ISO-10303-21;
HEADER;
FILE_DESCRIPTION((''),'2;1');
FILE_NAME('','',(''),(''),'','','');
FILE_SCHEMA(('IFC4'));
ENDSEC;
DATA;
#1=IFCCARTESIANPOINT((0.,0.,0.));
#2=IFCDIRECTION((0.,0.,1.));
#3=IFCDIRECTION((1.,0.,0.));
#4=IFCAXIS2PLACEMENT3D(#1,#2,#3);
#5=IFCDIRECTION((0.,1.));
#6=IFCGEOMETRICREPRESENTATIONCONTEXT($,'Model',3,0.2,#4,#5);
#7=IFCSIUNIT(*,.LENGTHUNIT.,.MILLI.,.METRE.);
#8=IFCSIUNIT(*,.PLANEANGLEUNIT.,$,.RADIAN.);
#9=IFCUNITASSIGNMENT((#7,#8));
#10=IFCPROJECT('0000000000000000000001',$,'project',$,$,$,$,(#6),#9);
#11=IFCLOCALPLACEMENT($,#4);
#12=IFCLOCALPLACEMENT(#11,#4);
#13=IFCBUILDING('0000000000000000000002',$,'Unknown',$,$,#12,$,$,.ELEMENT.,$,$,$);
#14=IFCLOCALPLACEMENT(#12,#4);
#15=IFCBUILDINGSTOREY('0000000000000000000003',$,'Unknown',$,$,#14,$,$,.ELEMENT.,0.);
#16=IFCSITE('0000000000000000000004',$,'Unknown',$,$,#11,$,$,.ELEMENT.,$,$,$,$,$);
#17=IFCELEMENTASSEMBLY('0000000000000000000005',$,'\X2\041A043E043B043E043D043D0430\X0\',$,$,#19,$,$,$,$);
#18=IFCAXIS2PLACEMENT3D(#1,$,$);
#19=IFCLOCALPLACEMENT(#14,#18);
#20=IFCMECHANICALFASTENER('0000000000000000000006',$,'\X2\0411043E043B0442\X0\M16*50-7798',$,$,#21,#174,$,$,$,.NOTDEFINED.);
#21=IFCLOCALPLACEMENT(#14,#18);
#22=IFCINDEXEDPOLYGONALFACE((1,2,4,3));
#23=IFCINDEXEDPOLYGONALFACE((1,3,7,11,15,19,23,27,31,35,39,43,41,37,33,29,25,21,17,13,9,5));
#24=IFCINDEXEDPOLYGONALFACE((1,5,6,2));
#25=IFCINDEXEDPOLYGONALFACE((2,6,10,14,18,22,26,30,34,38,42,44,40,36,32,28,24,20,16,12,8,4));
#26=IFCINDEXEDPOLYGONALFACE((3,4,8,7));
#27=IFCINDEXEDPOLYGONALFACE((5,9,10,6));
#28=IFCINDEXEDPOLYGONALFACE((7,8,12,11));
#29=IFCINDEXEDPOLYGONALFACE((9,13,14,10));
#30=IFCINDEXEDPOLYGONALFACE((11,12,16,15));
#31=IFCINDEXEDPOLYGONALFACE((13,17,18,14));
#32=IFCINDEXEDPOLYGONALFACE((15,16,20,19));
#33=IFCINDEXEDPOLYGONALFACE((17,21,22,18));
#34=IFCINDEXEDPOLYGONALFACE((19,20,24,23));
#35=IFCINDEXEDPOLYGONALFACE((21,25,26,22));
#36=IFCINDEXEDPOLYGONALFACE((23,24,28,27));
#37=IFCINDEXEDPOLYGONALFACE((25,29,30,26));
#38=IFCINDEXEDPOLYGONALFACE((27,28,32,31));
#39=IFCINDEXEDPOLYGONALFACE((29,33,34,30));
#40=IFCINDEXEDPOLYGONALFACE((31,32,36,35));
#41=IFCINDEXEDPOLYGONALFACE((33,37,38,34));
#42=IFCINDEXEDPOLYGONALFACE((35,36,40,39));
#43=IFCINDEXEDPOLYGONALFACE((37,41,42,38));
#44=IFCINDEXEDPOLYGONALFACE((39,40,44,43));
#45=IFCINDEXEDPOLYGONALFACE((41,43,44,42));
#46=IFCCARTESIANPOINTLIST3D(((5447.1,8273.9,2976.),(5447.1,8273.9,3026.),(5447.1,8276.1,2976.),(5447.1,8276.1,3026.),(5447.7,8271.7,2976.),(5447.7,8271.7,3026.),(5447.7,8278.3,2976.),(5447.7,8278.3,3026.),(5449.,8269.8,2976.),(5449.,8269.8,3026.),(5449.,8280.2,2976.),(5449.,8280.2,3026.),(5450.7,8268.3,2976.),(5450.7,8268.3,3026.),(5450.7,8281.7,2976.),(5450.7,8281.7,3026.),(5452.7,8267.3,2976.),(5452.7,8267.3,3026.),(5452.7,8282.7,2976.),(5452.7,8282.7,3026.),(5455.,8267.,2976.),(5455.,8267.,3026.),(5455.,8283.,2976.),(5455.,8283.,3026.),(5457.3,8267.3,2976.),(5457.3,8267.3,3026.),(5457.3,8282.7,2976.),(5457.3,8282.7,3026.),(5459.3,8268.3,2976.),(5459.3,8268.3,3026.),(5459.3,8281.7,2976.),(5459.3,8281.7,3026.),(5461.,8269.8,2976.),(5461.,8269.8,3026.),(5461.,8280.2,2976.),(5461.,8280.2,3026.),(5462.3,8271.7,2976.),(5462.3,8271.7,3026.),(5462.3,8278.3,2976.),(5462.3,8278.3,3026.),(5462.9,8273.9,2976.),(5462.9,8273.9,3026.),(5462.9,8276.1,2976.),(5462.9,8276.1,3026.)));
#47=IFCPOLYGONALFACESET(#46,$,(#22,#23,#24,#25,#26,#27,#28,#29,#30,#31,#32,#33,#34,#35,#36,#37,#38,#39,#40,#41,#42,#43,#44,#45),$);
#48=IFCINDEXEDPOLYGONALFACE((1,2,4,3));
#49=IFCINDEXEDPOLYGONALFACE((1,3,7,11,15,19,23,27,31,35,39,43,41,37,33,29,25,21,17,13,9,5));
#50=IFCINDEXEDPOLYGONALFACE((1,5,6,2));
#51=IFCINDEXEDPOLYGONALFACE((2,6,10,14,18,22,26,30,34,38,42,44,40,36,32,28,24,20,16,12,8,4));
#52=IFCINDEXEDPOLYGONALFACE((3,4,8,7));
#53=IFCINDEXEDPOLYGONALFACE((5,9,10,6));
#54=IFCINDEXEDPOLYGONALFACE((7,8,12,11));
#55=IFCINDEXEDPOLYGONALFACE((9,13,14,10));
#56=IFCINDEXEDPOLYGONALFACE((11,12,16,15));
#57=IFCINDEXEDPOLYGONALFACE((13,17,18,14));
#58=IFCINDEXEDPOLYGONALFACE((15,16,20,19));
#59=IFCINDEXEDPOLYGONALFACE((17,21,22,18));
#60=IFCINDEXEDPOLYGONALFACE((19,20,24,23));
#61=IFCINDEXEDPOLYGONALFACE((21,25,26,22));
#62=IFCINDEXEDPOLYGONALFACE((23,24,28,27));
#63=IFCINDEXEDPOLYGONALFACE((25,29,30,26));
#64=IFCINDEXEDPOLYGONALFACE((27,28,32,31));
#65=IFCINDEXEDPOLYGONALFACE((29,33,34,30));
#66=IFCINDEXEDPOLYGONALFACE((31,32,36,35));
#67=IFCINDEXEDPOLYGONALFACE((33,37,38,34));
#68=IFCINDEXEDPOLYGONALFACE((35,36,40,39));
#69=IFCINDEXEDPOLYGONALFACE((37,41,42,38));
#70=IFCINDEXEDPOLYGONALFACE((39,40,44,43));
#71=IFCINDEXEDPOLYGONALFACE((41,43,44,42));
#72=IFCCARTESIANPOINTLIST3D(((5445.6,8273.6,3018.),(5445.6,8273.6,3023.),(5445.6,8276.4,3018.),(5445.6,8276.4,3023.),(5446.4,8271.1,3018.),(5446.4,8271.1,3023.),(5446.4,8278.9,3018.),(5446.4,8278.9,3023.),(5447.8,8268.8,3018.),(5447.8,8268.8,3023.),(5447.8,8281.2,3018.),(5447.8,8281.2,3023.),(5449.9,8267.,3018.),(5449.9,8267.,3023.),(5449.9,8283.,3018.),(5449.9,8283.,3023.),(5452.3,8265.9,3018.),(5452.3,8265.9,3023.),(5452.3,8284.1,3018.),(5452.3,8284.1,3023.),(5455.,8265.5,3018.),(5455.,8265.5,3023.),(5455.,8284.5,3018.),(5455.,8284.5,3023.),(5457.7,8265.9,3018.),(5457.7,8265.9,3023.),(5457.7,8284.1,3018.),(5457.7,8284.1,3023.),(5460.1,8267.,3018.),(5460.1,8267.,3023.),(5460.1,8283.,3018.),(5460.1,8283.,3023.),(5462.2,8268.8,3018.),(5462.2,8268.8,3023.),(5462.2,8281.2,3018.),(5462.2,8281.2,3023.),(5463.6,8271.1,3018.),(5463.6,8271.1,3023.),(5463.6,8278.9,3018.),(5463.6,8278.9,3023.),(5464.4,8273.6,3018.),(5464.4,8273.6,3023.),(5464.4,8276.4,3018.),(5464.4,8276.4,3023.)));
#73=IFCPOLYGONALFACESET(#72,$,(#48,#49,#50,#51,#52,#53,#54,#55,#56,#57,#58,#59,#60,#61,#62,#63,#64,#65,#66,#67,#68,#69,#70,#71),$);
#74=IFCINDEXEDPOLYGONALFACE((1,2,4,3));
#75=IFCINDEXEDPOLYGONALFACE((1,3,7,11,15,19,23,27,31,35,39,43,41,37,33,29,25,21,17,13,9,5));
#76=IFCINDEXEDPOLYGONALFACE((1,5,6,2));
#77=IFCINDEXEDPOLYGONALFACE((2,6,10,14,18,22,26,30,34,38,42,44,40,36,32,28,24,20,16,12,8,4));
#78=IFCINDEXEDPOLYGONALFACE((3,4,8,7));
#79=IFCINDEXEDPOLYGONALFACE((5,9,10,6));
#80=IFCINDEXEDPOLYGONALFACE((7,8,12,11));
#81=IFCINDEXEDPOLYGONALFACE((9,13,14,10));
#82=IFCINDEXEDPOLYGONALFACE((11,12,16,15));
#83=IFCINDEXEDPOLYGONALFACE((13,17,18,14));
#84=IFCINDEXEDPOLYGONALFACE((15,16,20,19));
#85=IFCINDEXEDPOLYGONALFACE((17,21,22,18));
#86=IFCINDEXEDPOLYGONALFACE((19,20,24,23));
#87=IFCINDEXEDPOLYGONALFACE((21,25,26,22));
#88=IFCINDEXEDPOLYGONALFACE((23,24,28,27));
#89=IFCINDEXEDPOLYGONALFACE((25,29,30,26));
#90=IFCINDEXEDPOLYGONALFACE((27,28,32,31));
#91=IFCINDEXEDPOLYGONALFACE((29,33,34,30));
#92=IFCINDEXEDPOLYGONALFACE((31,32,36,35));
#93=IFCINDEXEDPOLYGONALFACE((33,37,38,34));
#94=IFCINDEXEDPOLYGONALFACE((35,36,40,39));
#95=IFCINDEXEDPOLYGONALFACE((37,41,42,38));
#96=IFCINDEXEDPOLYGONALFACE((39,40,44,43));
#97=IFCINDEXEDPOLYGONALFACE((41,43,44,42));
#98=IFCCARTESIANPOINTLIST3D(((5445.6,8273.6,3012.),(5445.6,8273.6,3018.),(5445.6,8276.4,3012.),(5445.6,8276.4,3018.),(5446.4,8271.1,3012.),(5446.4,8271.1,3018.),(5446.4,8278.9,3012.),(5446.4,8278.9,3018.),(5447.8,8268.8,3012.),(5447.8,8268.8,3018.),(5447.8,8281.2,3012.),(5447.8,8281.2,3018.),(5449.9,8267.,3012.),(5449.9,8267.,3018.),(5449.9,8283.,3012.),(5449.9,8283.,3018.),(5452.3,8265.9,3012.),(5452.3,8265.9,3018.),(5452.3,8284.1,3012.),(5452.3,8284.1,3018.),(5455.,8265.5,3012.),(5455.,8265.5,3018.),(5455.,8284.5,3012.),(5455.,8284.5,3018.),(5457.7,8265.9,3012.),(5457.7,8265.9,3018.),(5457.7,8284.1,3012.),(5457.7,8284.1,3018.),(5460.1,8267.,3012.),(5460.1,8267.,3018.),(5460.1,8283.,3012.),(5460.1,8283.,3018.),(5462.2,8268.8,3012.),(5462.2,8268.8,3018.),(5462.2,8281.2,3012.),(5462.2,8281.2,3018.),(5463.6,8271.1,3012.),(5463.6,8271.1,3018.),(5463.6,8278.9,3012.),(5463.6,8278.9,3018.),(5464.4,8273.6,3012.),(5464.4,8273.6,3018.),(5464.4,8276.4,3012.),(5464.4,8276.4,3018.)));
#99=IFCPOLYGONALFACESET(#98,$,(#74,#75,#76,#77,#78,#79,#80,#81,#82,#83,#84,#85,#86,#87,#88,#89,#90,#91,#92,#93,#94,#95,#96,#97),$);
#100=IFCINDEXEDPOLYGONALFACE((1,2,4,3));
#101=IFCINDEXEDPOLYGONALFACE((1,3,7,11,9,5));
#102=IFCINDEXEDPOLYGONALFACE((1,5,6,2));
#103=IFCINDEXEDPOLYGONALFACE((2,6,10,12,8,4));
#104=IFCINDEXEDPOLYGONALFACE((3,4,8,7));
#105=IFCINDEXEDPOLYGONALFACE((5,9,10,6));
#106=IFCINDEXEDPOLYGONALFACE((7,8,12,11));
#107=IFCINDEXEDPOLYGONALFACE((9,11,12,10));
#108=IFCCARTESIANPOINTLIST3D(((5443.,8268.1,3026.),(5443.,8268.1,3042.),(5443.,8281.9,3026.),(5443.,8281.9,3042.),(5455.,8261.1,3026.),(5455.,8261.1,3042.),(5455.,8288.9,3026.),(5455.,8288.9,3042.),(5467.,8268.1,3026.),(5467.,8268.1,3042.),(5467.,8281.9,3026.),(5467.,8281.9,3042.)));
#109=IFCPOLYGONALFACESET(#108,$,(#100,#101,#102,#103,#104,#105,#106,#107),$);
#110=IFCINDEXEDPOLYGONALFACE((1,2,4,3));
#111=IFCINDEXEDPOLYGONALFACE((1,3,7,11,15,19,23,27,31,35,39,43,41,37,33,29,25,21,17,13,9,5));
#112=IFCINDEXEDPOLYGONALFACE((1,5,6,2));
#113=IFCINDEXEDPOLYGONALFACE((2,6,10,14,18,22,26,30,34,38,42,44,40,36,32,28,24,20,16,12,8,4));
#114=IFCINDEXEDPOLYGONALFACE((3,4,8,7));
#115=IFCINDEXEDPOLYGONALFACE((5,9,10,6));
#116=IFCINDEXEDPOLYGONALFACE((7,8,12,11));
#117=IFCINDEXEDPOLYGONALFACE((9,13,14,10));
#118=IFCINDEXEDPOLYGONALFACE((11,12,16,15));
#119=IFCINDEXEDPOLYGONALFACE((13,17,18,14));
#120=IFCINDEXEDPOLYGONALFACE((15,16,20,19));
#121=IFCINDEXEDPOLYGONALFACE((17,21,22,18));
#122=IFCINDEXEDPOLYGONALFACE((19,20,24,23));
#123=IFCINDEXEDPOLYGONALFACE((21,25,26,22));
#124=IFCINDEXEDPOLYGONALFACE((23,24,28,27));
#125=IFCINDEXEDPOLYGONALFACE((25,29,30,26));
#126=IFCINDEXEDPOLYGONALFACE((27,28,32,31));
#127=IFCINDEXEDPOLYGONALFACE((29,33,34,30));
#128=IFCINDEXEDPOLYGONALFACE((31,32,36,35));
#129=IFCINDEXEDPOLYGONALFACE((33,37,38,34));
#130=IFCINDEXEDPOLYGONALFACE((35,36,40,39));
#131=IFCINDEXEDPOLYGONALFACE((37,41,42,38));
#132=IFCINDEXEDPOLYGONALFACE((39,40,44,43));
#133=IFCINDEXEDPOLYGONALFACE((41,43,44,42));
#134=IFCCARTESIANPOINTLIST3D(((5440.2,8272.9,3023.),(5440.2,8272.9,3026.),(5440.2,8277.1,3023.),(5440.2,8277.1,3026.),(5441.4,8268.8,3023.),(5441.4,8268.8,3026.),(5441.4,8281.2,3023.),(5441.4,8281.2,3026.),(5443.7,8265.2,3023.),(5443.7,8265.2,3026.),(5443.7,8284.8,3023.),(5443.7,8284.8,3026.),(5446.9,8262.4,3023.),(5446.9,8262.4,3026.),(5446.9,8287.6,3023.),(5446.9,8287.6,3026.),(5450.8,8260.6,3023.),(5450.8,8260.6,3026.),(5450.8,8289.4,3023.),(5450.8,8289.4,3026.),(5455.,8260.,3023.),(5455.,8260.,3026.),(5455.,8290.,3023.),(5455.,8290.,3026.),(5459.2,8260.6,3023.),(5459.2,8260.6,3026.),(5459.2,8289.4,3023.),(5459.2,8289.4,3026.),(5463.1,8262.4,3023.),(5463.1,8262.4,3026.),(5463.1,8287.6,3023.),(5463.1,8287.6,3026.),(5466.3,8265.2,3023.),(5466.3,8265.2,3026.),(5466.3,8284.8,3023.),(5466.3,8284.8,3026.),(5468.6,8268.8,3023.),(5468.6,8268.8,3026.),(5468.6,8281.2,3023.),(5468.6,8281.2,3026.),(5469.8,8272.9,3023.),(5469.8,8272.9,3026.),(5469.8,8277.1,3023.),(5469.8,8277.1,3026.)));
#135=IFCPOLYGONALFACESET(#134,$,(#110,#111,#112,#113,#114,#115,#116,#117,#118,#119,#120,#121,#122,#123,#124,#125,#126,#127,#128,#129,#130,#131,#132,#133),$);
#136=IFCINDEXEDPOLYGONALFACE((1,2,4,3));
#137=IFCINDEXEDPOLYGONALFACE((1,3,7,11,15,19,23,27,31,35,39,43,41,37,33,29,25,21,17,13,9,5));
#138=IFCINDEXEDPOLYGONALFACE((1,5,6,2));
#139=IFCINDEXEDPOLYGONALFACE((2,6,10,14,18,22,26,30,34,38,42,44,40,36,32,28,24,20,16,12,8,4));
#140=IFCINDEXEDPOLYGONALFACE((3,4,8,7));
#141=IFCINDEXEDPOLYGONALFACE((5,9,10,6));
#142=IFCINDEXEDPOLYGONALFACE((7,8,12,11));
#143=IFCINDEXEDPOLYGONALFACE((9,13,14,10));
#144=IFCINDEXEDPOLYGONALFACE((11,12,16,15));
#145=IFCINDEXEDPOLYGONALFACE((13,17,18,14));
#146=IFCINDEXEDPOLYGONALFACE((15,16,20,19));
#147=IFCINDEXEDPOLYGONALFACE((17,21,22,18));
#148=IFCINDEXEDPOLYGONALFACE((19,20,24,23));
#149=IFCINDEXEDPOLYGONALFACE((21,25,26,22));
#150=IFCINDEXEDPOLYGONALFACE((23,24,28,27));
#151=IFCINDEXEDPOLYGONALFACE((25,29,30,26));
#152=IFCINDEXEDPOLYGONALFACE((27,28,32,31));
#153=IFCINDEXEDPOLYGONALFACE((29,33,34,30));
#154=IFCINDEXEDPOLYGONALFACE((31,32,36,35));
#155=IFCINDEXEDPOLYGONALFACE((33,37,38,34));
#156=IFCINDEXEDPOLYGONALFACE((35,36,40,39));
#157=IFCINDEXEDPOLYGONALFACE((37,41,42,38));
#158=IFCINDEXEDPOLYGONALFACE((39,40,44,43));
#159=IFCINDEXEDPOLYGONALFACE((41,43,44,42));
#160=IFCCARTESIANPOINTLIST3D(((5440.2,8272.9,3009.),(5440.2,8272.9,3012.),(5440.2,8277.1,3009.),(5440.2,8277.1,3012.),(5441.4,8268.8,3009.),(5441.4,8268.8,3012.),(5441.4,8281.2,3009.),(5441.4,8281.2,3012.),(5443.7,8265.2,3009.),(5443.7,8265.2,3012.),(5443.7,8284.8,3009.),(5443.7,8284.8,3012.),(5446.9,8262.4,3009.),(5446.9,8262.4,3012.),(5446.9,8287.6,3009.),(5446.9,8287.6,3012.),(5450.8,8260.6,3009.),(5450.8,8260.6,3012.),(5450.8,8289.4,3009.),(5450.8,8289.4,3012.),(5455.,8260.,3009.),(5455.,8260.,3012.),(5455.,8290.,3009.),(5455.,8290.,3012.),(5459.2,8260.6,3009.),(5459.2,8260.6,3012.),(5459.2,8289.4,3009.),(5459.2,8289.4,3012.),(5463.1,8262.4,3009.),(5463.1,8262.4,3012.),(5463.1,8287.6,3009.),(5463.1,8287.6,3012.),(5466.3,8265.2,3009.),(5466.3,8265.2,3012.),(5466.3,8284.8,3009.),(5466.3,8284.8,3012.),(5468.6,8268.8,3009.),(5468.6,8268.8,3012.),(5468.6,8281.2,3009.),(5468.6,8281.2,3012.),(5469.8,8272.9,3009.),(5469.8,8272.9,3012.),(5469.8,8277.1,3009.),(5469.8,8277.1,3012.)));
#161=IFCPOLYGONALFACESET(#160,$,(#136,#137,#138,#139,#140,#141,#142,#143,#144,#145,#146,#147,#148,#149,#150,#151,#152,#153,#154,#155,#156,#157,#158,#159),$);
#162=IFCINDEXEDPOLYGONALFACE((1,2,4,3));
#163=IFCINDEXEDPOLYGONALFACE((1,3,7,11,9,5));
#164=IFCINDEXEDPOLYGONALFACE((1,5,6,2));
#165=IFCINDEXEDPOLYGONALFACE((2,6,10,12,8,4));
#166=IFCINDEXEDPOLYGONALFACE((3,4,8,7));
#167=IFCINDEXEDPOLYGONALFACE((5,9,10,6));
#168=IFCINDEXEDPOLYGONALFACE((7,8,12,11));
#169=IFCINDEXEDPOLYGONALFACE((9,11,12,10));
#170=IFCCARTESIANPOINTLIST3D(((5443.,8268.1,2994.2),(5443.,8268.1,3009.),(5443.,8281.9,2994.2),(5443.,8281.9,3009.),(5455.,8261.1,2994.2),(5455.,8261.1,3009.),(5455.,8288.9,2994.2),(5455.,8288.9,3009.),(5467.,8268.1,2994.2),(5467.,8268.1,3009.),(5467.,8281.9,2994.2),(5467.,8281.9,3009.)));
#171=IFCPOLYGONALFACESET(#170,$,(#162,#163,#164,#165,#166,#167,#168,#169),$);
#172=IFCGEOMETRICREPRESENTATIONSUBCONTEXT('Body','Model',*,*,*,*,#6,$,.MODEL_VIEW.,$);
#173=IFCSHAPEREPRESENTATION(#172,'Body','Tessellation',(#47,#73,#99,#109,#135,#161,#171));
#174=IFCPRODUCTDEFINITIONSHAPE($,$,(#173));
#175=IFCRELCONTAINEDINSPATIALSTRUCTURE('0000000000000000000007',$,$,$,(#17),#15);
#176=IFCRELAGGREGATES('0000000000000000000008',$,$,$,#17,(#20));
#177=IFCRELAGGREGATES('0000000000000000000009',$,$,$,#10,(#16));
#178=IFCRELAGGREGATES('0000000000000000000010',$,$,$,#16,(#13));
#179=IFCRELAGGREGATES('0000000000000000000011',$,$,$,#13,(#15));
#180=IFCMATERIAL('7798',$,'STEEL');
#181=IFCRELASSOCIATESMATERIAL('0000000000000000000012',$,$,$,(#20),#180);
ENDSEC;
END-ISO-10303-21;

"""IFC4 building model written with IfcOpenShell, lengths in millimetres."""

from ifc_helpers import new_model, si_unit, direction, frame, origin_with_axes, place, context, subcontext, project, spatial, line, arc, indexed_curve, outline, extrude, source, transform, mapped, material, element, aggregate, save


model = new_model("IFC4")

# Units and contexts
model_context = context("Model", 3, precision=0.2, world=origin_with_axes(), true_north=direction((0.0, 1.0)))
body_context = subcontext(model_context, "Body", "Model", "MODEL_VIEW")
ifc_project = project(units=[si_unit("LENGTHUNIT", "METRE", prefix="MILLI"), si_unit("PLANEANGLEUNIT", "RADIAN")], contexts=[model_context])

# Site, building, storey
site_placement = place(None, origin_with_axes())
site = spatial("IfcSite", under=ifc_project, at=site_placement, Name="Unknown", CompositionType="ELEMENT")
building_placement = place(site_placement, origin_with_axes())
building = spatial("IfcBuilding", under=site, at=building_placement, Name="Unknown", CompositionType="ELEMENT")
storey_placement = place(building_placement, origin_with_axes())
storey = spatial("IfcBuildingStorey", under=building, at=storey_placement, Name="Unknown", CompositionType="ELEMENT", Elevation=0.0)

# Element assembly
assembly_1_placement = place(storey_placement, frame((5400.0, 8400.0, -40.0), z_axis=(-1.0, 0.0, 0.0), x_axis=(0.0, 0.0, 1.0)))
assembly_1 = element("IfcElementAssembly", 1, at=assembly_1_placement, inside=storey, Name="Колонна")

# Mechanical fastener
ifc_material_1 = material(Name="7798", Category="STEEL")
shared_shape_1 = source(origin_with_axes(), body_context, "Body", "SweptSolid", [
    extrude(outline(indexed_curve([(8.0, 0.0), (0.0, 8.0), (-8.0, 0.0), (0.0, -8.0)], segments=[arc(1, 2, 3), arc(3, 4, 1)])), frame((0.0, 0.0, 8.0), z_axis=(0.0, 0.0, -1.0), x_axis=(0.0, 1.0, 0.0)), (0.0, 0.0, 1.0), 50.0),
    extrude(outline(indexed_curve([(9.5, 0.0), (0.0, 9.5), (-9.5, 0.0), (0.0, -9.5)], segments=[arc(1, 2, 3), arc(3, 4, 1)])), frame((0.0, 0.0, 5.0), z_axis=(0.0, 0.0, -1.0), x_axis=(0.0, 1.0, 0.0)), (0.0, 0.0, 1.0), 5.0),
    extrude(outline(indexed_curve([(9.5, 0.0), (0.0, 9.5), (-9.5, 0.0), (0.0, -9.5)], segments=[arc(1, 2, 3), arc(3, 4, 1)])), frame((0.0, 0.0, 0.0), z_axis=(0.0, 0.0, -1.0), x_axis=(0.0, 1.0, 0.0)), (0.0, 0.0, 1.0), 6.0),
    extrude(outline(indexed_curve([(13.9, 0.0), (6.9, 12.0), (-6.9, 12.0), (-13.9, 0.0), (-6.9, -12.0), (6.9, -12.0)], segments=[line(1, 2, 3, 4, 5, 6, 1)])), frame((0.0, 0.0, 24.0), z_axis=(0.0, 0.0, -1.0), x_axis=(0.0, 1.0, 0.0)), (0.0, 0.0, 1.0), 16.0),
    extrude(outline(indexed_curve([(15.0, 0.0), (0.0, 15.0), (-15.0, 0.0), (0.0, -15.0)], segments=[arc(1, 2, 3), arc(3, 4, 1)])), frame((0.0, 0.0, 8.0), z_axis=(0.0, 0.0, -1.0), x_axis=(0.0, 1.0, 0.0)), (0.0, 0.0, 1.0), 3.0),
    extrude(outline(indexed_curve([(15.0, 0.0), (0.0, 15.0), (-15.0, 0.0), (0.0, -15.0)], segments=[arc(1, 2, 3), arc(3, 4, 1)])), frame((0.0, 0.0, -6.0), z_axis=(0.0, 0.0, -1.0), x_axis=(0.0, 1.0, 0.0)), (0.0, 0.0, 1.0), 3.0),
    extrude(outline(indexed_curve([(13.9, 0.0), (6.9, 12.0), (-6.9, 12.0), (-13.9, 0.0), (-6.9, -12.0), (6.9, -12.0)], segments=[line(1, 2, 3, 4, 5, 6, 1)])), frame((0.0, 0.0, -9.0), z_axis=(0.0, 0.0, -1.0), x_axis=(0.0, 1.0, 0.0)), (0.0, 0.0, 1.0), 14.8),
])
mechanical_fastener_1_placement = place(assembly_1_placement, frame((3058.0, -125.0, -55.0), z_axis=(1.0, 0.0, 0.0), x_axis=(0.0, 0.0, 1.0)))
mechanical_fastener_1 = element("IfcMechanicalFastener", 2, at=mechanical_fastener_1_placement, material=ifc_material_1, Name="БолтM16*50-7798", PredefinedType="NOTDEFINED", context=body_context, shape_type="MappedRepresentation", body=[
    mapped(shared_shape_1, transform((0.0, 0.0, 0.0))),
])
aggregate(assembly_1, [mechanical_fastener_1])

save(model, "model.ifc")
